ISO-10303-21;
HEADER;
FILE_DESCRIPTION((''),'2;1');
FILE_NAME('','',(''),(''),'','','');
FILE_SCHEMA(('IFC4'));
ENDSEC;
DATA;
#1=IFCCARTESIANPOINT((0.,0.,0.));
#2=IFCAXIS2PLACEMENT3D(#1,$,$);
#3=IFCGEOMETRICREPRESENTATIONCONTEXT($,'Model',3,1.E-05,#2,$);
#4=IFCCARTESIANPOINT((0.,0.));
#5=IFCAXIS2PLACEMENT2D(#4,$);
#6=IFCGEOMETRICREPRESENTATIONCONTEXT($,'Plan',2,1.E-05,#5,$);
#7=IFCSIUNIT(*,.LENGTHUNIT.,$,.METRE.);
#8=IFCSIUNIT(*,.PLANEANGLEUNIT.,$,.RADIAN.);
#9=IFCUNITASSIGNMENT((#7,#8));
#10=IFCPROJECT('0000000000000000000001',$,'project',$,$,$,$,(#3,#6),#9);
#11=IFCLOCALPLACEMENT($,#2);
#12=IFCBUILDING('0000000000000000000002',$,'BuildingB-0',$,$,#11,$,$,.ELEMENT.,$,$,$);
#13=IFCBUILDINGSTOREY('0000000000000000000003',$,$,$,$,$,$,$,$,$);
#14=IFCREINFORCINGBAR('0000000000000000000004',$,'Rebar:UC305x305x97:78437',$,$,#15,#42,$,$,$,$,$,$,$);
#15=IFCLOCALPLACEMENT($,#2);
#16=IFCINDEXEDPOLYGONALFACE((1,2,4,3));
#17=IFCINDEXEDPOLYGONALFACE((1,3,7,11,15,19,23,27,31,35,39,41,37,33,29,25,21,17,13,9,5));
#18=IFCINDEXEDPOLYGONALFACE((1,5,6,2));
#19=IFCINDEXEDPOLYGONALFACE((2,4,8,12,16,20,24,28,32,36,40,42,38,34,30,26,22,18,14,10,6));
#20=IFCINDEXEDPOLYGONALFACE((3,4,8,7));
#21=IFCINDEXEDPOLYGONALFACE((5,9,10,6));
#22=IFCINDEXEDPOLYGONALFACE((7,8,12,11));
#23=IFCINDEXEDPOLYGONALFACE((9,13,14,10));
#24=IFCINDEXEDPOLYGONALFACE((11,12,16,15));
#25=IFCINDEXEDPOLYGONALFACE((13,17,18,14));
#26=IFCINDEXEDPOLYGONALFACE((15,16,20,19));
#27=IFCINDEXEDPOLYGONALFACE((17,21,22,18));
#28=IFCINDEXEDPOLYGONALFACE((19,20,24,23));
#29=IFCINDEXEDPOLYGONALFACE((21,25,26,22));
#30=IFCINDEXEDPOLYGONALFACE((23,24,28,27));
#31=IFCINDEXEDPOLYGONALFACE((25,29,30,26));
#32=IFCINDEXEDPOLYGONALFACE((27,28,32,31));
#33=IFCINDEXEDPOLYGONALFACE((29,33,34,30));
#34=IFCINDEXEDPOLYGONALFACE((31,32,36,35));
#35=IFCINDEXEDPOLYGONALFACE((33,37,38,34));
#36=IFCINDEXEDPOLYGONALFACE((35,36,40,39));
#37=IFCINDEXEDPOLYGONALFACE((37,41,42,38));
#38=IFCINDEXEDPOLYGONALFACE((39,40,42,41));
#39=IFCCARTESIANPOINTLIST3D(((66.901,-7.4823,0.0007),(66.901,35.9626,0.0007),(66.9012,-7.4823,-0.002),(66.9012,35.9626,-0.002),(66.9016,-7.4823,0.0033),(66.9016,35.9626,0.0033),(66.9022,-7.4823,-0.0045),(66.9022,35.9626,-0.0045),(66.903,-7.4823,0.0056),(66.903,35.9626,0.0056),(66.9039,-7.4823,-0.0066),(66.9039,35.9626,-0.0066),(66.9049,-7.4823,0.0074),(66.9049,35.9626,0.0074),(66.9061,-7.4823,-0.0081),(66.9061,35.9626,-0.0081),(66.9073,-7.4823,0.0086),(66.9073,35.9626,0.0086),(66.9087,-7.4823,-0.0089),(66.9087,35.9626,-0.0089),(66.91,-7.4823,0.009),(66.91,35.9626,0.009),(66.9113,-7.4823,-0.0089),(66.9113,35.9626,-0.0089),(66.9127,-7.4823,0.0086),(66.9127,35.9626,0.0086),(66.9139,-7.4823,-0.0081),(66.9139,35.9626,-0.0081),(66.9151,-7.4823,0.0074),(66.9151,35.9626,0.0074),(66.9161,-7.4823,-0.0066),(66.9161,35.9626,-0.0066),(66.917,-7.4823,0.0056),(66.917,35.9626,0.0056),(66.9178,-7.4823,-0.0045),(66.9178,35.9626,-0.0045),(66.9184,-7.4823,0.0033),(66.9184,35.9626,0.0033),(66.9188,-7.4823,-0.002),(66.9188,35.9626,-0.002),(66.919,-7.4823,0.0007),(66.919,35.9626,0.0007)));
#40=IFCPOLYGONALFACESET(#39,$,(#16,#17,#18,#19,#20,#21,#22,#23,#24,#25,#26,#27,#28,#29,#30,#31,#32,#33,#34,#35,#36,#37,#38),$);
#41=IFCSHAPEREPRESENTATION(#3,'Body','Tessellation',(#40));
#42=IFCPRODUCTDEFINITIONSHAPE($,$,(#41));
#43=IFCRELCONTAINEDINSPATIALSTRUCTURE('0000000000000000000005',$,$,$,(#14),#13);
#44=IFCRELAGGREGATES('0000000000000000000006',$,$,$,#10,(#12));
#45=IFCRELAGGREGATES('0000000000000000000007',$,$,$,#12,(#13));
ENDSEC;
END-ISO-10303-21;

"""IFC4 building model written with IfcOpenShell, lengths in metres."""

from ifc_helpers import new_model, entity, si_unit, origin, origin_2d, place, context, project, spatial, element, save


model = new_model("IFC4")

# Units and contexts
model_context = context("Model", 3, precision=1e-05, world=origin())
plan_context = context("Plan", 2, precision=1e-05, world=origin_2d())
ifc_project = project(units=[si_unit("LENGTHUNIT", "METRE"), si_unit("PLANEANGLEUNIT", "RADIAN")], contexts=[model_context, plan_context])

# Building, storey
building_placement = place(None, origin())
building = spatial("IfcBuilding", under=ifc_project, at=building_placement, Name="BuildingB-0", CompositionType="ELEMENT")
storey = spatial("IfcBuildingStorey", under=building)

# Reinforcing bar
element("IfcReinforcingBar", 1, inside=storey, Name="Rebar:UC305x305x97:78437", context=model_context, shape_type="SweptSolid", body=[
    entity("IfcSurfaceCurveSweptAreaSolid", entity("IfcCircleProfileDef", "AREA", None, None, 0.009), None, entity("IfcPolyline", [entity("IfcCartesianPoint", [66.91, 35.9626, 0.0]), entity("IfcCartesianPoint", [66.91, -7.4823, 0.0])]), None, None, entity("IfcPlane", entity("IfcAxis2Placement3D", entity("IfcCartesianPoint", [66.91, 35.9626, 0.0]), entity("IfcDirection", [0.0, 0.0, 1.0]), entity("IfcDirection", [1.0, 0.0, 0.0])))),
])

save(model, "model.ifc")
